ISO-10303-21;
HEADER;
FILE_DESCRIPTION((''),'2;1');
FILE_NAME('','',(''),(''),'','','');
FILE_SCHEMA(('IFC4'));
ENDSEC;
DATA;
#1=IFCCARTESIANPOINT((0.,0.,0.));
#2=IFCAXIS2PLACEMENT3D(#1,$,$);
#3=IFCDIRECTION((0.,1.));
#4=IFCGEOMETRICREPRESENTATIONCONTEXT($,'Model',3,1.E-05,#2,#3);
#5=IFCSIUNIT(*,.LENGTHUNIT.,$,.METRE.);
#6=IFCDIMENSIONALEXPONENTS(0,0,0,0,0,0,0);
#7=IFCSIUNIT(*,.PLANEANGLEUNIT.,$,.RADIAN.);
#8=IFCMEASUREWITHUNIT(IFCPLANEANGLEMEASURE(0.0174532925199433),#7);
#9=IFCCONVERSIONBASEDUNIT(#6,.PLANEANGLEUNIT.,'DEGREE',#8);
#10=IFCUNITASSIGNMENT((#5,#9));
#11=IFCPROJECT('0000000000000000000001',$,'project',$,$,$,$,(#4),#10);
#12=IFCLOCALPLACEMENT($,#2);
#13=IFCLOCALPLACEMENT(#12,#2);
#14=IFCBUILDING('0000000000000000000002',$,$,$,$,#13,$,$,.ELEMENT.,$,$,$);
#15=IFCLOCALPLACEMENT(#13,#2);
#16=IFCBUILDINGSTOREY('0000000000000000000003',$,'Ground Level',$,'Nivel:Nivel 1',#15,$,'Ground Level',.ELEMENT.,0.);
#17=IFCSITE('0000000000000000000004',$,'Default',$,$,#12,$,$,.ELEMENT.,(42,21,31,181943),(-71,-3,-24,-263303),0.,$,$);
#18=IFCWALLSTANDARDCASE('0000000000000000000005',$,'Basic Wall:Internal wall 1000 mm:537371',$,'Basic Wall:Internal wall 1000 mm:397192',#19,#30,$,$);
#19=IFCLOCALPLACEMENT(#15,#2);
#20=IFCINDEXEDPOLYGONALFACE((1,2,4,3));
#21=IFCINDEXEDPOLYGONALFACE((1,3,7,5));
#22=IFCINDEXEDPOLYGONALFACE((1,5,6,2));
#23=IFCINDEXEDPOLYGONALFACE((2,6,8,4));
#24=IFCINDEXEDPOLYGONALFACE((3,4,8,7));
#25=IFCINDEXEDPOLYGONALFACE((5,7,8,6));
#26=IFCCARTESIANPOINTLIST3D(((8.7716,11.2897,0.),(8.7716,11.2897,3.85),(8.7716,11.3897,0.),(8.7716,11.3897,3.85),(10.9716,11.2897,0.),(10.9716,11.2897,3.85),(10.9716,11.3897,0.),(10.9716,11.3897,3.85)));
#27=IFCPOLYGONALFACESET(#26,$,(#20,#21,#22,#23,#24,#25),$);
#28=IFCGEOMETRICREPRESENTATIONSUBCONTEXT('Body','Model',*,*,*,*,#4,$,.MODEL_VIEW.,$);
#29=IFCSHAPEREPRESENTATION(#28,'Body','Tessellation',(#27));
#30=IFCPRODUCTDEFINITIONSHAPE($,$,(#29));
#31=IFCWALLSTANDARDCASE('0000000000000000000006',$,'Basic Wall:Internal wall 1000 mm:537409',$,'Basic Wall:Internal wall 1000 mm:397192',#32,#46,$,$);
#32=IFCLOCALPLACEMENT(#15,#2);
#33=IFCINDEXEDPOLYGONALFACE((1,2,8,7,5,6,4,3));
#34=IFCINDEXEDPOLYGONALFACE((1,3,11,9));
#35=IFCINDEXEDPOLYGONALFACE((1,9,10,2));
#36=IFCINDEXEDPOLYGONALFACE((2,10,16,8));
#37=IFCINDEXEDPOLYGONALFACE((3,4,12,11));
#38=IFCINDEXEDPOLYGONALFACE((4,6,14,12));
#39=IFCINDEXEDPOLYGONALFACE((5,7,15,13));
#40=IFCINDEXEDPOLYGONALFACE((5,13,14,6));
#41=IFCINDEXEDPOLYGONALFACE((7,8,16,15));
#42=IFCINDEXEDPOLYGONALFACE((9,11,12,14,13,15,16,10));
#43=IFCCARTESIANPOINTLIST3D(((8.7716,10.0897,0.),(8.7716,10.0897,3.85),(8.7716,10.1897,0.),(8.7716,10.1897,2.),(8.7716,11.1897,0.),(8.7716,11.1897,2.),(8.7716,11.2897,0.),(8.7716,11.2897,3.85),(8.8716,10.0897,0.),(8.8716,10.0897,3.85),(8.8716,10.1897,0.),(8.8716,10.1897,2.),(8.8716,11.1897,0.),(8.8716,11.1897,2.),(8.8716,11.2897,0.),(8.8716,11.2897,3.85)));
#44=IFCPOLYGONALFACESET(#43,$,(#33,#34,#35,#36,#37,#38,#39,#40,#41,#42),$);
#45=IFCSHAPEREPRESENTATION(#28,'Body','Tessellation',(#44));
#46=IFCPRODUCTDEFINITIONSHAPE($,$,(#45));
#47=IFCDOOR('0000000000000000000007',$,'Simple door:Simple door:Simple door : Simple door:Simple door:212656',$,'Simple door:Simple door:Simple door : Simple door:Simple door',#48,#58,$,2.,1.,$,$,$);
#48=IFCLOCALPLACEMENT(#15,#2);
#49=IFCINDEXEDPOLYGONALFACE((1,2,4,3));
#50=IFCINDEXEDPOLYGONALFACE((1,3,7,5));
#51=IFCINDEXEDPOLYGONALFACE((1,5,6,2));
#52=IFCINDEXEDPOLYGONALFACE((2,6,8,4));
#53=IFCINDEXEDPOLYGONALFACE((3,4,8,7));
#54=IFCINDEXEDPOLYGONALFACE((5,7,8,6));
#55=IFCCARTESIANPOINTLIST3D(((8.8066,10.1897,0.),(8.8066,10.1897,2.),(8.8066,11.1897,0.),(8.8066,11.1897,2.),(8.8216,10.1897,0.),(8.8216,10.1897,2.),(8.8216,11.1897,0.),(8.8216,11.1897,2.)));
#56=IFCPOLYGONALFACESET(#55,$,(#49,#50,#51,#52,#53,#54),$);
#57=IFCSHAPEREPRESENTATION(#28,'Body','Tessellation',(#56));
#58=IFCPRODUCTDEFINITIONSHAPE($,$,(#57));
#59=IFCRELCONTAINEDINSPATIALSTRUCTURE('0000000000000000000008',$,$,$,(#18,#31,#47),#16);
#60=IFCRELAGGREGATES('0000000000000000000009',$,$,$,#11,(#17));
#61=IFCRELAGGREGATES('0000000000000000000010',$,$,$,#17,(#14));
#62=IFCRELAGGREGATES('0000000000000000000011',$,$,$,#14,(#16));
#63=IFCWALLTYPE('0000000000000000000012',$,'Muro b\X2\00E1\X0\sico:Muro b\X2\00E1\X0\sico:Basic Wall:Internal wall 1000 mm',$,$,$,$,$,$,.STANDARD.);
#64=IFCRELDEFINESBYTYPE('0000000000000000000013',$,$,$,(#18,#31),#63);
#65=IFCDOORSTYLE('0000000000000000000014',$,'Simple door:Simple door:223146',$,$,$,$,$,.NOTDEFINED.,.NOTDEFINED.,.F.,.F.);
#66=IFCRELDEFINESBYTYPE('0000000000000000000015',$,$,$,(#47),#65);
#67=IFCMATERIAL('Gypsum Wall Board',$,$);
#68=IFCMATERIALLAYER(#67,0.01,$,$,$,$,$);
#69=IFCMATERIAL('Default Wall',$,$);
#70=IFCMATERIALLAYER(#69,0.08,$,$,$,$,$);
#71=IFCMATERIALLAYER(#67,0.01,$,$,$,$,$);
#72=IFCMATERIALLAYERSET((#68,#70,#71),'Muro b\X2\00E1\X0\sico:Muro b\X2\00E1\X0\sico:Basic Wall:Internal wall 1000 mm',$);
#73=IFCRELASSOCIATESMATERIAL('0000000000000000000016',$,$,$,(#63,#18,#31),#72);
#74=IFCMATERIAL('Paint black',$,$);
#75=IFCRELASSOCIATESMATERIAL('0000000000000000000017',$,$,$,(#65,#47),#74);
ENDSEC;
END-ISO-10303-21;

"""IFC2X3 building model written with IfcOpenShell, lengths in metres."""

from ifc_helpers import new_model, entity, si_unit, converted_unit, direction, frame, frame_2d, origin, origin_2d_with_axis, place, context, subcontext, project, spatial, rectangle, extrude, source, transform, mapped, material, layer, layer_set, layer_usage, type_object, type_shapes, element, fill, save


model = new_model("IFC2X3")

# Units and contexts
model_context = context("Model", 3, precision=1e-05, world=origin(), true_north=direction((0.0, 1.0)))
body_context = subcontext(model_context, "Body", "Model", "MODEL_VIEW")
ifc_project = project(units=[si_unit("LENGTHUNIT", "METRE"), converted_unit("PLANEANGLEUNIT", "DEGREE", entity("IfcPlaneAngleMeasure", 0.0174532925199433), si_unit("PLANEANGLEUNIT", "RADIAN"), dimensions=[0, 0, 0, 0, 0, 0, 0])], contexts=[model_context])

# Site, building, storey
site_placement = place(None, origin())
site = spatial("IfcSite", under=ifc_project, at=site_placement, Name="Default", CompositionType="ELEMENT", RefLatitude=(42, 21, 31, 181943), RefLongitude=(-71, -3, -24, -263303), RefElevation=0.0)
building_placement = place(site_placement, origin())
building = spatial("IfcBuilding", under=site, at=building_placement, CompositionType="ELEMENT")
storey_placement = place(building_placement, origin())
storey = spatial("IfcBuildingStorey", under=building, at=storey_placement, Name="Ground Level", ObjectType="Nivel:Nivel 1", LongName="Ground Level", CompositionType="ELEMENT", Elevation=0.0)

# Shared definitions
ifc_material_1 = material(Name="Gypsum Wall Board")
ifc_layer_1 = layer(ifc_material_1, 0.01)
ifc_material_2 = material(Name="Default Wall")
ifc_layer_2 = layer(ifc_material_2, 0.08)
ifc_layer_3 = layer(ifc_material_1, 0.01)
ifc_layer_set_1 = layer_set([ifc_layer_1, ifc_layer_2, ifc_layer_3], Name="Muro básico:Muro básico:Basic Wall:Internal wall 1000 mm")
wall_type = type_object("IfcWallType", Name="Muro básico:Muro básico:Basic Wall:Internal wall 1000 mm", PredefinedType="STANDARD", material=ifc_layer_set_1)

# Shared definitions
ifc_material_3 = material(Name="Paint black")
door_style_1 = type_object("IfcDoorStyle", Name="Simple door:Simple door:223146", ConstructionType="NOTDEFINED", OperationType="NOTDEFINED", ParameterTakesPrecedence=False, Sizeable=False, material=ifc_material_3)
shared_shape_1 = source(origin(), body_context, "Body", "SweptSolid", [
    extrude(rectangle(XDim=1.0, YDim=0.015, at=origin_2d_with_axis()), frame((0.5, -0.0595, 0.0)), (0.0, 0.0, 1.0), 2.0),
])
type_shapes(door_style_1, [shared_shape_1])

# Wall
ifc_layer_usage_1 = layer_usage(ifc_layer_set_1, "AXIS2", "NEGATIVE", 0.05)
wall_1_placement = place(storey_placement, frame((10.9716, 11.3397, 0.0), z_axis=(0.0, 0.0, 1.0), x_axis=(-1.0, 0.0, 0.0)))
element("IfcWallStandardCase", 1, at=wall_1_placement, inside=storey, type_object=wall_type, material=ifc_layer_usage_1, Name="Basic Wall:Internal wall 1000 mm:537371", ObjectType="Basic Wall:Internal wall 1000 mm:397192", context=body_context, shape_type="SweptSolid", body=[
    extrude(rectangle(XDim=2.2, YDim=0.1, at=frame_2d((1.1, 0.0), x_axis=(-1.0, 0.0))), origin(), (0.0, 0.0, 1.0), 3.85),
])

# Wall, opening, door
ifc_layer_usage_2 = layer_usage(ifc_layer_set_1, "AXIS2", "NEGATIVE", 0.05)
wall_2_placement = place(storey_placement, frame((8.8216, 11.2897, 0.0), z_axis=(0.0, 0.0, 1.0), x_axis=(0.0, -1.0, 0.0)))
wall_2 = element("IfcWallStandardCase", 2, at=wall_2_placement, inside=storey, type_object=wall_type, material=ifc_layer_usage_2, Name="Basic Wall:Internal wall 1000 mm:537409", ObjectType="Basic Wall:Internal wall 1000 mm:397192", context=body_context, shape_type="SweptSolid", body=[
    extrude(rectangle(XDim=1.2, YDim=0.1, at=frame_2d((0.6, 0.0), x_axis=(1.0, 0.0))), origin(), (0.0, 0.0, 1.0), 3.85),
])
opening_1_placement = place(wall_2_placement, frame((11.2897, -8.8216, 0.0), z_axis=(0.0, 0.0, 1.0), x_axis=(0.0, 1.0, 0.0)))
opening_1 = element("IfcOpeningElement", 3, at=opening_1_placement, cuts=wall_2, ObjectType="Opening", context=body_context, shape_type="SweptSolid", body=[
    extrude(rectangle(XDim=2.0, YDim=1.0, at=frame_2d((0.0, 0.0), x_axis=(0.0, 1.0))), frame((8.7696, 10.6897, 1.0), z_axis=(1.0, 0.0, 0.0), x_axis=(0.0, 1.0, 0.0)), (0.0, 0.0, 1.0), 0.104),
])
door_1_placement = place(opening_1_placement, frame((8.8736, 11.1897, 0.0), z_axis=(0.0, 0.0, 1.0), x_axis=(0.0, -1.0, 0.0)))
door_1 = element("IfcDoor", 4, at=door_1_placement, inside=storey, type_object=door_style_1, material=ifc_material_3, Name="Simple door:Simple door:Simple door : Simple door:Simple door:212656", ObjectType="Simple door:Simple door:Simple door : Simple door:Simple door", OverallHeight=2.0, OverallWidth=1.0, context=body_context, shape_type="MappedRepresentation", body=[
    mapped(shared_shape_1, transform((0.0, 0.0, 0.0), scale=1.0)),
])
fill(opening_1, door_1)

save(model, "model.ifc")
